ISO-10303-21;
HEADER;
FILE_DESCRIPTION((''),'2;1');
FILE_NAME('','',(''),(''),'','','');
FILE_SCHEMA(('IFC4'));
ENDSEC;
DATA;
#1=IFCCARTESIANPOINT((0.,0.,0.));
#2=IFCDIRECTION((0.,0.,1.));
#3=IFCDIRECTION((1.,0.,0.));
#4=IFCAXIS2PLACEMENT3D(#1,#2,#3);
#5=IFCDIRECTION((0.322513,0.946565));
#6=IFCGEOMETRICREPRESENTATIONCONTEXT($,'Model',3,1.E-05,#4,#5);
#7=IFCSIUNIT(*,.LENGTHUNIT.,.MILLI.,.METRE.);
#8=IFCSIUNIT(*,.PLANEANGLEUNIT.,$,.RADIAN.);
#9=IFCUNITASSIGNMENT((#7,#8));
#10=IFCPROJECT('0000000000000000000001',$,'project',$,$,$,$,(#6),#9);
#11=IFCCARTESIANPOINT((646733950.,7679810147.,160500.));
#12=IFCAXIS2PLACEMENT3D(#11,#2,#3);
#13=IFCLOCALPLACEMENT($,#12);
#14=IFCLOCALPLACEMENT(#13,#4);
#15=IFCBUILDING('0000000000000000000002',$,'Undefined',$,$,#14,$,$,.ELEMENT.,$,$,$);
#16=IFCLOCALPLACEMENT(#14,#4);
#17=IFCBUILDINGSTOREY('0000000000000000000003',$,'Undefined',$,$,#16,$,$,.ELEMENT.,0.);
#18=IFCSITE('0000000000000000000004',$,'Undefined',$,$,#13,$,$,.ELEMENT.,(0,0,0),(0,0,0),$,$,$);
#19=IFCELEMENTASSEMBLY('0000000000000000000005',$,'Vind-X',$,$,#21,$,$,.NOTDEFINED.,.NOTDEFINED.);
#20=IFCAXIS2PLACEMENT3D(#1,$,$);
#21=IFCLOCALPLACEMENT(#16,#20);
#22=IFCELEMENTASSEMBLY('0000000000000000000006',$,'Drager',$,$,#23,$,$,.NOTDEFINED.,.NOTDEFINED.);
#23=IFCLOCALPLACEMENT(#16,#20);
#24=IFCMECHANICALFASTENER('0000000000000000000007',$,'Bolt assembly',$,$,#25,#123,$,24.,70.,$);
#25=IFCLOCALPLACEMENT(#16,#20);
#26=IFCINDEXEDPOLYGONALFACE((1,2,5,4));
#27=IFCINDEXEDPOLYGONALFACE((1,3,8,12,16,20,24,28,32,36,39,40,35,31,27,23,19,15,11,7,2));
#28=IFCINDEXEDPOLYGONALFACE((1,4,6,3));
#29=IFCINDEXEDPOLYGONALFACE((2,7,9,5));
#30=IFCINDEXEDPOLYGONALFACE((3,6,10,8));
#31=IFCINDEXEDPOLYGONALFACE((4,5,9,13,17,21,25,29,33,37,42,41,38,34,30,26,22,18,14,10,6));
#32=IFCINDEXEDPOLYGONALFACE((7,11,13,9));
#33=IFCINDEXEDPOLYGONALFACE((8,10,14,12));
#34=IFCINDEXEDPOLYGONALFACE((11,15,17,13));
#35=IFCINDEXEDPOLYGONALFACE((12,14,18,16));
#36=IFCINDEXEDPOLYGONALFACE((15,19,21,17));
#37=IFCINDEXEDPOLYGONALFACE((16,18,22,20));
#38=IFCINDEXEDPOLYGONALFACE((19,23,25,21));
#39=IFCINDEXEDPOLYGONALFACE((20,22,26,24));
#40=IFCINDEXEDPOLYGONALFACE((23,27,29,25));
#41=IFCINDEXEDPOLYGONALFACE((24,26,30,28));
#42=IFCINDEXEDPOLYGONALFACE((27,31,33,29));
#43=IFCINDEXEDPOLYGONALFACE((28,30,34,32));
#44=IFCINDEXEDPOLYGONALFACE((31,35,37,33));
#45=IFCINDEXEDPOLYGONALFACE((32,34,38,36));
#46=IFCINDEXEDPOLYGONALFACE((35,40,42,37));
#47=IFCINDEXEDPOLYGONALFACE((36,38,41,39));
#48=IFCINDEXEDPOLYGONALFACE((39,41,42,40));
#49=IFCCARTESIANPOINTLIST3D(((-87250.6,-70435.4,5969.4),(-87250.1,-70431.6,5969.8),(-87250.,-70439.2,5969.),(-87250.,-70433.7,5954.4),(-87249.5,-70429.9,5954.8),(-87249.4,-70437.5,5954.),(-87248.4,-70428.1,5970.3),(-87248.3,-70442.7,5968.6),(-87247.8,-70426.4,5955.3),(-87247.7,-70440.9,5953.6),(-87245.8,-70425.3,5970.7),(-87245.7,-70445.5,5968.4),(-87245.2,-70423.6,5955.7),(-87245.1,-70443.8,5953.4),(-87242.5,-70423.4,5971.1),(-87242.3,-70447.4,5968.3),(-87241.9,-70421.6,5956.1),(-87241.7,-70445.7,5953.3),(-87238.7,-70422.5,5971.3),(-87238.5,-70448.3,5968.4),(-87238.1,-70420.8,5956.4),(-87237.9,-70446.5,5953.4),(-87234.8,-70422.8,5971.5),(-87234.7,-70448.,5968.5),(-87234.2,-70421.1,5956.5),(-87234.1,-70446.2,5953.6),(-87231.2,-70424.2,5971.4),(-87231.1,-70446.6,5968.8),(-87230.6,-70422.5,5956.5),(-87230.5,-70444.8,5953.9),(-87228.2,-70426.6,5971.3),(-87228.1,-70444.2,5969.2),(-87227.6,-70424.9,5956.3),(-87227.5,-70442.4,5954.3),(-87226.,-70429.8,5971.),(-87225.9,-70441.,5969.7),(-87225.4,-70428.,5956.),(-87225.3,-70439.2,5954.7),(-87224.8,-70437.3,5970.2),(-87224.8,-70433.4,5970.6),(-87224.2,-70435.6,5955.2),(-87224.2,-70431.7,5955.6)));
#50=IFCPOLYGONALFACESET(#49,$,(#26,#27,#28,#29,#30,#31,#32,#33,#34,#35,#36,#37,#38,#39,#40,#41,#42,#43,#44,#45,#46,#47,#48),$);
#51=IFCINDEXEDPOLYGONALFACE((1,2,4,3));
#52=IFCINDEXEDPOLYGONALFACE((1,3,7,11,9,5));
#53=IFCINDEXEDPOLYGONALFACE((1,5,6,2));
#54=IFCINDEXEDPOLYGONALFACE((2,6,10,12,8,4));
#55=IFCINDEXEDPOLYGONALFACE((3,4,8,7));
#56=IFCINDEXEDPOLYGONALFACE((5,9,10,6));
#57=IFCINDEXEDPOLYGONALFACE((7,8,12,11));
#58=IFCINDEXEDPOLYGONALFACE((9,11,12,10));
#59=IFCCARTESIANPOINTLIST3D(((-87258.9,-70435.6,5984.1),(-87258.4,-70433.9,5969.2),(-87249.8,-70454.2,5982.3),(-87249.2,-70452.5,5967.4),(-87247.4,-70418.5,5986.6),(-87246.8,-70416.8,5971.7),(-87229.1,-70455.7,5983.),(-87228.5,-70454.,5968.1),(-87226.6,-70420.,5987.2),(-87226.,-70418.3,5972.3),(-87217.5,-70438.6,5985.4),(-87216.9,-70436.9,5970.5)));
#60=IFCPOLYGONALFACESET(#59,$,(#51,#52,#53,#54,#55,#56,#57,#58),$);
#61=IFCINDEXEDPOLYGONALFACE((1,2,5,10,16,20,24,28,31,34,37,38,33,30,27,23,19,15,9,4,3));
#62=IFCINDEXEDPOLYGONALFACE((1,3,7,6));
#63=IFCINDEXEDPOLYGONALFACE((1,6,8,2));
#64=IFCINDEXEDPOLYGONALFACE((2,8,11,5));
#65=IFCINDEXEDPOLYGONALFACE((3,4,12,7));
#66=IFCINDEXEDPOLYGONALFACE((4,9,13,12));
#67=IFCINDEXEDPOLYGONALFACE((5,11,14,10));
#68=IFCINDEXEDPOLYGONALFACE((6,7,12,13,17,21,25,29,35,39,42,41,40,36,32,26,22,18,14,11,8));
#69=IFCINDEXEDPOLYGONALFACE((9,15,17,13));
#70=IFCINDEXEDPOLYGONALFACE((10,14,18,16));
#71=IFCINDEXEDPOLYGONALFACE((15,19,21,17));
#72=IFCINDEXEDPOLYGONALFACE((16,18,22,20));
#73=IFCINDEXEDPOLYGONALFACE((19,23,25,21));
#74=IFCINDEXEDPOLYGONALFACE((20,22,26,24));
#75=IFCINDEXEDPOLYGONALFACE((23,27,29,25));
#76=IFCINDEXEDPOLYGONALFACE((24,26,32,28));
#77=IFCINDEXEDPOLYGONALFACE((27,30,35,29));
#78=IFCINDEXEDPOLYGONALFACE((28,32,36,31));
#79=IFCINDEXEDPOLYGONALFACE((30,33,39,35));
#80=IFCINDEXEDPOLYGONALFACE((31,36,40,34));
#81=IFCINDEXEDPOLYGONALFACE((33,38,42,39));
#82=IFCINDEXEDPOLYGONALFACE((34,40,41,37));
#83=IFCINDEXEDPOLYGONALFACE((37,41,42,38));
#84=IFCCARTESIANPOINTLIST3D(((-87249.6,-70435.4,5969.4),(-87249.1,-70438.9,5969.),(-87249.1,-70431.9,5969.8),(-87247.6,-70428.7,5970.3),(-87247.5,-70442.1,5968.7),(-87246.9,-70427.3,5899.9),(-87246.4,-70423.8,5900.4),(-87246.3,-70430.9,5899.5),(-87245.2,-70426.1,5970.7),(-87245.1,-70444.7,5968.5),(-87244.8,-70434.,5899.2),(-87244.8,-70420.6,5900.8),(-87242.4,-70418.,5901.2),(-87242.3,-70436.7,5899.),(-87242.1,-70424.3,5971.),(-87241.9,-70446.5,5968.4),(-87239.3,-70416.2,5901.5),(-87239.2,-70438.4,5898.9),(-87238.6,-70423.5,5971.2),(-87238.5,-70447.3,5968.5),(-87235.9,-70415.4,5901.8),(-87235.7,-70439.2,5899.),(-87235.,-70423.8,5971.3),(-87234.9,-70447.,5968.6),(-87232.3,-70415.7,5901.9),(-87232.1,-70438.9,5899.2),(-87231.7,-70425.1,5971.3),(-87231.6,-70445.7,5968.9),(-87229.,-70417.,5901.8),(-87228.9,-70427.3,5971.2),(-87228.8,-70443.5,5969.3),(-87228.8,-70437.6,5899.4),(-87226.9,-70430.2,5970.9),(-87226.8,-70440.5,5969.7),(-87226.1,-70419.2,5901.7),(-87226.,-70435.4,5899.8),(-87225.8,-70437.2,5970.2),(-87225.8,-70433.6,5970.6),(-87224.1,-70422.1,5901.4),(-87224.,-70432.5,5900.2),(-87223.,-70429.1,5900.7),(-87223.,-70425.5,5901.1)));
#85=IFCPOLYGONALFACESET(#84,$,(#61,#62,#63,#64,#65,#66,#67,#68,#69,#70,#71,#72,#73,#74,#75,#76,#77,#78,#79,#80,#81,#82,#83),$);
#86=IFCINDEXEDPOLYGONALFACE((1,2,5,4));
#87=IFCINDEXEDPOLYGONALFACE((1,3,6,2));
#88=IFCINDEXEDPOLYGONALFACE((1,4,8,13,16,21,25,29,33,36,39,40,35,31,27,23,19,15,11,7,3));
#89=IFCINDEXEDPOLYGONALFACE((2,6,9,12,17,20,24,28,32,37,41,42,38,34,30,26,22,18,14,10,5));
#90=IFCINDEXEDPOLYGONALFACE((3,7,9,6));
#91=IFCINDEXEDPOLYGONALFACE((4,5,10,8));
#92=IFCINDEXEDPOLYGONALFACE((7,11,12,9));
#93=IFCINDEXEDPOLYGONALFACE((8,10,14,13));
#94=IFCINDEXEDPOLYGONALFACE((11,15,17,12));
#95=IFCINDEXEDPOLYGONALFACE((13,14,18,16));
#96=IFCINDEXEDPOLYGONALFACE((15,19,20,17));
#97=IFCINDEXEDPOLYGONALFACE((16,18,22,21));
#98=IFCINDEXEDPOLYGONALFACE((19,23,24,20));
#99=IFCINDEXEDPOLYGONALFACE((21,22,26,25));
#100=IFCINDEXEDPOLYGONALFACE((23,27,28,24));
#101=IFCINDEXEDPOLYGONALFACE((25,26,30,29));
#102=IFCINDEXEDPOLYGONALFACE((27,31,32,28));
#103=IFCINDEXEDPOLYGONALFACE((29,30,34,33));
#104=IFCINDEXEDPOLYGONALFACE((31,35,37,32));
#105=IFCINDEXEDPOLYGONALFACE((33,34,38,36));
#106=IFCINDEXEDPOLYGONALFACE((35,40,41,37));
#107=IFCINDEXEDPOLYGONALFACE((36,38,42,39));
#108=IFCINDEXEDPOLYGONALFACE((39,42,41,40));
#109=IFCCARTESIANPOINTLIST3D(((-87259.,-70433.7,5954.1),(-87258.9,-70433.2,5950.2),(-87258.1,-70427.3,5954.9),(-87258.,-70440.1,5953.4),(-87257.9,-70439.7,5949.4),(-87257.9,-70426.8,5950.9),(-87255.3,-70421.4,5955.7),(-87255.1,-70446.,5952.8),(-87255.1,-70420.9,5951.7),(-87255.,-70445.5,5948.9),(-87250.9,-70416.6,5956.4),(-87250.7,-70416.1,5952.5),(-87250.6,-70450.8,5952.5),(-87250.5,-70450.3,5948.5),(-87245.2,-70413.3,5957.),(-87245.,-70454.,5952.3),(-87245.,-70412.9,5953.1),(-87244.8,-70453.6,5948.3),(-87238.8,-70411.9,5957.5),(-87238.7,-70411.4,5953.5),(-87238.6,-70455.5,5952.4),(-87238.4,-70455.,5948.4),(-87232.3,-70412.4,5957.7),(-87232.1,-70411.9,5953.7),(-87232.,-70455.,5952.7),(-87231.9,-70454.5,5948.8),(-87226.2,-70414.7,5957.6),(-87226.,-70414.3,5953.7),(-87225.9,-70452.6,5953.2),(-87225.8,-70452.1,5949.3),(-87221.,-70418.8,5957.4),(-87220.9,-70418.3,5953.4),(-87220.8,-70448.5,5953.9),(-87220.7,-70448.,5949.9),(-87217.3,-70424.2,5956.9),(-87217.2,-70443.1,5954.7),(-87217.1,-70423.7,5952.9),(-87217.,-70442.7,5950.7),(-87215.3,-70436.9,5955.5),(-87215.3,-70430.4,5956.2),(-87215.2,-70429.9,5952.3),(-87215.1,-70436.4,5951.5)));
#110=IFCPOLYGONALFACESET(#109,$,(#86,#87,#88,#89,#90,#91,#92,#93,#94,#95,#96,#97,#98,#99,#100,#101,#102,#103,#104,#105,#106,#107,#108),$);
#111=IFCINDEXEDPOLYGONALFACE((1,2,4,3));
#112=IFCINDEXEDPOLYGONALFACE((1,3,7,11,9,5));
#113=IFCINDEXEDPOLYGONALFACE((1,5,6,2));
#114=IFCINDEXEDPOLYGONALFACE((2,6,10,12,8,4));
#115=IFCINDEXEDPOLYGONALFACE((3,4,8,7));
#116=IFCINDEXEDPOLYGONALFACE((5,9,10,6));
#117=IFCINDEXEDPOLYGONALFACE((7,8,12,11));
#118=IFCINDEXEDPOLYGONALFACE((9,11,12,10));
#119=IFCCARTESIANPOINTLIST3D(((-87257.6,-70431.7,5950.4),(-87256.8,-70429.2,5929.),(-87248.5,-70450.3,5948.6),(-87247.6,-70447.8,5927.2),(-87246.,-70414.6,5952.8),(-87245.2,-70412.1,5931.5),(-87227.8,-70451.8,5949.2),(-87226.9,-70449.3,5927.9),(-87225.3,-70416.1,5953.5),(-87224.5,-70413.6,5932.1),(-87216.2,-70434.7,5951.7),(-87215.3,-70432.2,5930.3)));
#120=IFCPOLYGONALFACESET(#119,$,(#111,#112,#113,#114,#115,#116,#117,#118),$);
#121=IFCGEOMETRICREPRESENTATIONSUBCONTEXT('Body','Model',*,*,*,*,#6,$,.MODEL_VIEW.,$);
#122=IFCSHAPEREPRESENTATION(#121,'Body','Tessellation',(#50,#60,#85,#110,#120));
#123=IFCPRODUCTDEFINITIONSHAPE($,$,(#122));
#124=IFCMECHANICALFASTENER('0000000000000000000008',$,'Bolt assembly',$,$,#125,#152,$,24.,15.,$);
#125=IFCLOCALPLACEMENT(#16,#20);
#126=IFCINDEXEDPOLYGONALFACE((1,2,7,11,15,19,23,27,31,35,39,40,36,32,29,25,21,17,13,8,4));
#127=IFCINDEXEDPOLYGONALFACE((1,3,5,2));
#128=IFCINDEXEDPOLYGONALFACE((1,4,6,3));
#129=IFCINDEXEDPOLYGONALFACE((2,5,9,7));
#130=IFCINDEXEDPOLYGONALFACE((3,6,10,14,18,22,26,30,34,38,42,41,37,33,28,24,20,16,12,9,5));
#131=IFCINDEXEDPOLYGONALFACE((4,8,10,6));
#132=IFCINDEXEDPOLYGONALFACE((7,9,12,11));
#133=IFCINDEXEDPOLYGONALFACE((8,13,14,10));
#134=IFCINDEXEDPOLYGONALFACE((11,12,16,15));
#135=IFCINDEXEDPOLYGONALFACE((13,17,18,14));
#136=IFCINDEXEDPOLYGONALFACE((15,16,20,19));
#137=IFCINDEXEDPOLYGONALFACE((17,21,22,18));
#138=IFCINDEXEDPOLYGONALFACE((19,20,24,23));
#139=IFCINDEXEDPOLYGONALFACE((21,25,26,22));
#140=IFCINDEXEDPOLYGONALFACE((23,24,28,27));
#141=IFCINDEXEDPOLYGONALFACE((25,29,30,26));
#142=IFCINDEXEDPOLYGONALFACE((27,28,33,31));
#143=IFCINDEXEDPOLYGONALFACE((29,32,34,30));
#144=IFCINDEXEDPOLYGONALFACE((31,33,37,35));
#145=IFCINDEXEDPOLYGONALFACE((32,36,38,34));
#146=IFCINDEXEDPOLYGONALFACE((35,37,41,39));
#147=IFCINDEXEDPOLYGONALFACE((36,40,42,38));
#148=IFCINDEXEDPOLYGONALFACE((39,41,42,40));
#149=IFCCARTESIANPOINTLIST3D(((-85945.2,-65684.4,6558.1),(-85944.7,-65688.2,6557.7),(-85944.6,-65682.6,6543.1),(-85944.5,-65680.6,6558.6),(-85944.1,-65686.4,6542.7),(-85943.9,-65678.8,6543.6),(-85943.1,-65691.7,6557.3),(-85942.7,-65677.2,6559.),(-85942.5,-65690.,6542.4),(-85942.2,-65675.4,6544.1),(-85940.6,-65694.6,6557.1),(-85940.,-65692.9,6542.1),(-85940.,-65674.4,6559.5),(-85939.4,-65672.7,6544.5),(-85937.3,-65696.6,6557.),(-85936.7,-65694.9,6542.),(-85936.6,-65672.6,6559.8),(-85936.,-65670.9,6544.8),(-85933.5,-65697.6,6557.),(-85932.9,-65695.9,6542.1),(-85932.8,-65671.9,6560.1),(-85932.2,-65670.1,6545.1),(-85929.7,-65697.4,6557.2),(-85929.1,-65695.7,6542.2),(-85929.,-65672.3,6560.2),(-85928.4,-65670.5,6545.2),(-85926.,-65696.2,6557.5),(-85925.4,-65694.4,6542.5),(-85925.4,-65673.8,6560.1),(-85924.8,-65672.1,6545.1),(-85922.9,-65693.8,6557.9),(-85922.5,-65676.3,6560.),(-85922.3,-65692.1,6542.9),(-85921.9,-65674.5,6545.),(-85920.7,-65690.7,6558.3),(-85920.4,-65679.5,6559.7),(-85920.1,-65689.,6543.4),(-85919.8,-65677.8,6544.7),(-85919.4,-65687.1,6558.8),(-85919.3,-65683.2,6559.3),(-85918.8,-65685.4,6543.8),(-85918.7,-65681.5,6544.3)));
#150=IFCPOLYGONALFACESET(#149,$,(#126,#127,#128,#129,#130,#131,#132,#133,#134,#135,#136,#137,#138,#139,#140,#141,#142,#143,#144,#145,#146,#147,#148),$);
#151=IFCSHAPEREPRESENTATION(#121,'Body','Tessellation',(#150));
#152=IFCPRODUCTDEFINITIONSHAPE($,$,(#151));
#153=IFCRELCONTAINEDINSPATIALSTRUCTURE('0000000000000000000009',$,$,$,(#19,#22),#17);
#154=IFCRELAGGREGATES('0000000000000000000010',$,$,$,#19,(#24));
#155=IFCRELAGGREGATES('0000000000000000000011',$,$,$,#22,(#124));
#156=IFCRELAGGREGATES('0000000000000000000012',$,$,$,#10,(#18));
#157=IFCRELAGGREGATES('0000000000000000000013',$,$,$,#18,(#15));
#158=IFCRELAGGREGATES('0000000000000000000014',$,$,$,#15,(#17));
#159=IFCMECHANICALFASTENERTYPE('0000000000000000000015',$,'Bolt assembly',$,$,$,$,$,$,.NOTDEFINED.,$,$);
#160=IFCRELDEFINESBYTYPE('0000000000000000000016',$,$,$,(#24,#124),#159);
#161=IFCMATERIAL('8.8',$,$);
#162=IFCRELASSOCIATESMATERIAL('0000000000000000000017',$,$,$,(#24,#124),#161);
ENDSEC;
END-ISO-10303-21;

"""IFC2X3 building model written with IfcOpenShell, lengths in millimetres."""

from ifc_helpers import new_model, si_unit, direction, frame, origin_with_axes, origin_2d_with_axis, place, context, subcontext, project, spatial, polyline, circle, outline, extrude, source, transform, mapped, material, type_object, element, aggregate, save


model = new_model("IFC2X3")

# Units and contexts
model_context = context("Model", 3, precision=1e-05, world=origin_with_axes(), true_north=direction((0.322513, 0.946565)))
body_context = subcontext(model_context, "Body", "Model", "MODEL_VIEW")
ifc_project = project(units=[si_unit("LENGTHUNIT", "METRE", prefix="MILLI"), si_unit("PLANEANGLEUNIT", "RADIAN")], contexts=[model_context])

# Site, building, storey
site_placement = place(None, frame((646733950.0, 7679810147.0, 160500.0), z_axis=(0.0, 0.0, 1.0), x_axis=(1.0, 0.0, 0.0)))
site = spatial("IfcSite", under=ifc_project, at=site_placement, Name="Undefined", CompositionType="ELEMENT", RefLatitude=(0, 0, 0), RefLongitude=(0, 0, 0))
building_placement = place(site_placement, origin_with_axes())
building = spatial("IfcBuilding", under=site, at=building_placement, Name="Undefined", CompositionType="ELEMENT")
storey_placement = place(building_placement, origin_with_axes())
storey = spatial("IfcBuildingStorey", under=building, at=storey_placement, Name="Undefined", CompositionType="ELEMENT", Elevation=0.0)

# Element assembly
assembly_1_placement = place(storey_placement, origin_with_axes())
assembly_1 = element("IfcElementAssembly", 1, at=assembly_1_placement, inside=storey, Name="Vind-X", AssemblyPlace="NOTDEFINED", PredefinedType="NOTDEFINED")

# Element assembly
assembly_2_placement = place(storey_placement, origin_with_axes())
assembly_2 = element("IfcElementAssembly", 2, at=assembly_2_placement, inside=storey, Name="Drager", AssemblyPlace="NOTDEFINED", PredefinedType="NOTDEFINED")

# Mechanical fasteners
ifc_material_1 = material(Name="8.8")
mechanical_fastener_type = type_object("IfcMechanicalFastenerType", Name="Bolt assembly")
shared_shape_1 = source(origin_with_axes(), body_context, "Body", "SweptSolid", [
    extrude(circle(Radius=13.0, at=origin_2d_with_axis()), frame((0.0, 0.0, 0.0), z_axis=(0.0, 1.0, 0.0), x_axis=(1.0, 0.0, 0.0)), (0.0, 0.0, 1.0), 15.1),
    extrude(outline(polyline([(18.0, -10.4), (18.0, 10.4), (0.0, 20.8), (-18.0, 10.4), (-18.0, -10.4), (0.0, -20.8), (18.0, -10.4)])), frame((0.0, -15.0, 0.0), z_axis=(0.0, 1.0, 0.0), x_axis=(1.0, 0.0, 0.0)), (0.0, 0.0, 1.0), 15.0),
    extrude(circle(Radius=12.0, at=origin_2d_with_axis()), frame((0.0, 0.0, 0.0), z_axis=(0.0, 1.0, 0.0), x_axis=(1.0, 0.0, 0.0)), (0.0, 0.0, 1.0), 70.0),
    extrude(circle(Radius=22.0, at=origin_2d_with_axis()), frame((0.0, 15.0, 0.0), z_axis=(0.0, 1.0, 0.0), x_axis=(1.0, 0.0, 0.0)), (0.0, 0.0, 1.0), 4.0),
    extrude(outline(polyline([(18.0, -10.4), (18.0, 10.4), (0.0, 20.8), (-18.0, 10.4), (-18.0, -10.4), (0.0, -20.8), (18.0, -10.4)])), frame((0.0, 19.0, 0.0), z_axis=(0.0, 1.0, 0.0), x_axis=(1.0, 0.0, 0.0)), (0.0, 0.0, 1.0), 21.5),
])
mechanical_fastener_1_placement = place(assembly_1_placement, frame((-87237.6, -70435.4, 5969.9), z_axis=(-0.439079, 0.89427, 0.086548), x_axis=(0.897588, 0.432405, 0.0858)))
mechanical_fastener_1 = element("IfcMechanicalFastener", 3, at=mechanical_fastener_1_placement, type_object=mechanical_fastener_type, material=ifc_material_1, Name="Bolt assembly", NominalDiameter=24.0, NominalLength=70.0, context=body_context, shape_type="MappedRepresentation", body=[
    mapped(shared_shape_1, transform((0.0, 0.0, 0.0))),
])
aggregate(assembly_1, [mechanical_fastener_1])
shared_shape_2 = source(origin_with_axes(), body_context, "Body", "SweptSolid", [
    extrude(circle(Radius=13.0, at=origin_2d_with_axis()), frame((0.0, -7.5, 0.0), z_axis=(0.0, 1.0, 0.0), x_axis=(1.0, 0.0, 0.0)), (0.0, 0.0, 1.0), 15.1),
])
mechanical_fastener_2_placement = place(assembly_2_placement, frame((-85931.9, -65683.9, 6551.2), z_axis=(-0.320109, -0.93951, -0.121869), x_axis=(-0.946565, 0.322513, 0.0)))
mechanical_fastener_2 = element("IfcMechanicalFastener", 4, at=mechanical_fastener_2_placement, type_object=mechanical_fastener_type, material=ifc_material_1, Name="Bolt assembly", NominalDiameter=24.0, NominalLength=15.0, context=body_context, shape_type="MappedRepresentation", body=[
    mapped(shared_shape_2, transform((0.0, 0.0, 0.0))),
])
aggregate(assembly_2, [mechanical_fastener_2])

save(model, "model.ifc")
